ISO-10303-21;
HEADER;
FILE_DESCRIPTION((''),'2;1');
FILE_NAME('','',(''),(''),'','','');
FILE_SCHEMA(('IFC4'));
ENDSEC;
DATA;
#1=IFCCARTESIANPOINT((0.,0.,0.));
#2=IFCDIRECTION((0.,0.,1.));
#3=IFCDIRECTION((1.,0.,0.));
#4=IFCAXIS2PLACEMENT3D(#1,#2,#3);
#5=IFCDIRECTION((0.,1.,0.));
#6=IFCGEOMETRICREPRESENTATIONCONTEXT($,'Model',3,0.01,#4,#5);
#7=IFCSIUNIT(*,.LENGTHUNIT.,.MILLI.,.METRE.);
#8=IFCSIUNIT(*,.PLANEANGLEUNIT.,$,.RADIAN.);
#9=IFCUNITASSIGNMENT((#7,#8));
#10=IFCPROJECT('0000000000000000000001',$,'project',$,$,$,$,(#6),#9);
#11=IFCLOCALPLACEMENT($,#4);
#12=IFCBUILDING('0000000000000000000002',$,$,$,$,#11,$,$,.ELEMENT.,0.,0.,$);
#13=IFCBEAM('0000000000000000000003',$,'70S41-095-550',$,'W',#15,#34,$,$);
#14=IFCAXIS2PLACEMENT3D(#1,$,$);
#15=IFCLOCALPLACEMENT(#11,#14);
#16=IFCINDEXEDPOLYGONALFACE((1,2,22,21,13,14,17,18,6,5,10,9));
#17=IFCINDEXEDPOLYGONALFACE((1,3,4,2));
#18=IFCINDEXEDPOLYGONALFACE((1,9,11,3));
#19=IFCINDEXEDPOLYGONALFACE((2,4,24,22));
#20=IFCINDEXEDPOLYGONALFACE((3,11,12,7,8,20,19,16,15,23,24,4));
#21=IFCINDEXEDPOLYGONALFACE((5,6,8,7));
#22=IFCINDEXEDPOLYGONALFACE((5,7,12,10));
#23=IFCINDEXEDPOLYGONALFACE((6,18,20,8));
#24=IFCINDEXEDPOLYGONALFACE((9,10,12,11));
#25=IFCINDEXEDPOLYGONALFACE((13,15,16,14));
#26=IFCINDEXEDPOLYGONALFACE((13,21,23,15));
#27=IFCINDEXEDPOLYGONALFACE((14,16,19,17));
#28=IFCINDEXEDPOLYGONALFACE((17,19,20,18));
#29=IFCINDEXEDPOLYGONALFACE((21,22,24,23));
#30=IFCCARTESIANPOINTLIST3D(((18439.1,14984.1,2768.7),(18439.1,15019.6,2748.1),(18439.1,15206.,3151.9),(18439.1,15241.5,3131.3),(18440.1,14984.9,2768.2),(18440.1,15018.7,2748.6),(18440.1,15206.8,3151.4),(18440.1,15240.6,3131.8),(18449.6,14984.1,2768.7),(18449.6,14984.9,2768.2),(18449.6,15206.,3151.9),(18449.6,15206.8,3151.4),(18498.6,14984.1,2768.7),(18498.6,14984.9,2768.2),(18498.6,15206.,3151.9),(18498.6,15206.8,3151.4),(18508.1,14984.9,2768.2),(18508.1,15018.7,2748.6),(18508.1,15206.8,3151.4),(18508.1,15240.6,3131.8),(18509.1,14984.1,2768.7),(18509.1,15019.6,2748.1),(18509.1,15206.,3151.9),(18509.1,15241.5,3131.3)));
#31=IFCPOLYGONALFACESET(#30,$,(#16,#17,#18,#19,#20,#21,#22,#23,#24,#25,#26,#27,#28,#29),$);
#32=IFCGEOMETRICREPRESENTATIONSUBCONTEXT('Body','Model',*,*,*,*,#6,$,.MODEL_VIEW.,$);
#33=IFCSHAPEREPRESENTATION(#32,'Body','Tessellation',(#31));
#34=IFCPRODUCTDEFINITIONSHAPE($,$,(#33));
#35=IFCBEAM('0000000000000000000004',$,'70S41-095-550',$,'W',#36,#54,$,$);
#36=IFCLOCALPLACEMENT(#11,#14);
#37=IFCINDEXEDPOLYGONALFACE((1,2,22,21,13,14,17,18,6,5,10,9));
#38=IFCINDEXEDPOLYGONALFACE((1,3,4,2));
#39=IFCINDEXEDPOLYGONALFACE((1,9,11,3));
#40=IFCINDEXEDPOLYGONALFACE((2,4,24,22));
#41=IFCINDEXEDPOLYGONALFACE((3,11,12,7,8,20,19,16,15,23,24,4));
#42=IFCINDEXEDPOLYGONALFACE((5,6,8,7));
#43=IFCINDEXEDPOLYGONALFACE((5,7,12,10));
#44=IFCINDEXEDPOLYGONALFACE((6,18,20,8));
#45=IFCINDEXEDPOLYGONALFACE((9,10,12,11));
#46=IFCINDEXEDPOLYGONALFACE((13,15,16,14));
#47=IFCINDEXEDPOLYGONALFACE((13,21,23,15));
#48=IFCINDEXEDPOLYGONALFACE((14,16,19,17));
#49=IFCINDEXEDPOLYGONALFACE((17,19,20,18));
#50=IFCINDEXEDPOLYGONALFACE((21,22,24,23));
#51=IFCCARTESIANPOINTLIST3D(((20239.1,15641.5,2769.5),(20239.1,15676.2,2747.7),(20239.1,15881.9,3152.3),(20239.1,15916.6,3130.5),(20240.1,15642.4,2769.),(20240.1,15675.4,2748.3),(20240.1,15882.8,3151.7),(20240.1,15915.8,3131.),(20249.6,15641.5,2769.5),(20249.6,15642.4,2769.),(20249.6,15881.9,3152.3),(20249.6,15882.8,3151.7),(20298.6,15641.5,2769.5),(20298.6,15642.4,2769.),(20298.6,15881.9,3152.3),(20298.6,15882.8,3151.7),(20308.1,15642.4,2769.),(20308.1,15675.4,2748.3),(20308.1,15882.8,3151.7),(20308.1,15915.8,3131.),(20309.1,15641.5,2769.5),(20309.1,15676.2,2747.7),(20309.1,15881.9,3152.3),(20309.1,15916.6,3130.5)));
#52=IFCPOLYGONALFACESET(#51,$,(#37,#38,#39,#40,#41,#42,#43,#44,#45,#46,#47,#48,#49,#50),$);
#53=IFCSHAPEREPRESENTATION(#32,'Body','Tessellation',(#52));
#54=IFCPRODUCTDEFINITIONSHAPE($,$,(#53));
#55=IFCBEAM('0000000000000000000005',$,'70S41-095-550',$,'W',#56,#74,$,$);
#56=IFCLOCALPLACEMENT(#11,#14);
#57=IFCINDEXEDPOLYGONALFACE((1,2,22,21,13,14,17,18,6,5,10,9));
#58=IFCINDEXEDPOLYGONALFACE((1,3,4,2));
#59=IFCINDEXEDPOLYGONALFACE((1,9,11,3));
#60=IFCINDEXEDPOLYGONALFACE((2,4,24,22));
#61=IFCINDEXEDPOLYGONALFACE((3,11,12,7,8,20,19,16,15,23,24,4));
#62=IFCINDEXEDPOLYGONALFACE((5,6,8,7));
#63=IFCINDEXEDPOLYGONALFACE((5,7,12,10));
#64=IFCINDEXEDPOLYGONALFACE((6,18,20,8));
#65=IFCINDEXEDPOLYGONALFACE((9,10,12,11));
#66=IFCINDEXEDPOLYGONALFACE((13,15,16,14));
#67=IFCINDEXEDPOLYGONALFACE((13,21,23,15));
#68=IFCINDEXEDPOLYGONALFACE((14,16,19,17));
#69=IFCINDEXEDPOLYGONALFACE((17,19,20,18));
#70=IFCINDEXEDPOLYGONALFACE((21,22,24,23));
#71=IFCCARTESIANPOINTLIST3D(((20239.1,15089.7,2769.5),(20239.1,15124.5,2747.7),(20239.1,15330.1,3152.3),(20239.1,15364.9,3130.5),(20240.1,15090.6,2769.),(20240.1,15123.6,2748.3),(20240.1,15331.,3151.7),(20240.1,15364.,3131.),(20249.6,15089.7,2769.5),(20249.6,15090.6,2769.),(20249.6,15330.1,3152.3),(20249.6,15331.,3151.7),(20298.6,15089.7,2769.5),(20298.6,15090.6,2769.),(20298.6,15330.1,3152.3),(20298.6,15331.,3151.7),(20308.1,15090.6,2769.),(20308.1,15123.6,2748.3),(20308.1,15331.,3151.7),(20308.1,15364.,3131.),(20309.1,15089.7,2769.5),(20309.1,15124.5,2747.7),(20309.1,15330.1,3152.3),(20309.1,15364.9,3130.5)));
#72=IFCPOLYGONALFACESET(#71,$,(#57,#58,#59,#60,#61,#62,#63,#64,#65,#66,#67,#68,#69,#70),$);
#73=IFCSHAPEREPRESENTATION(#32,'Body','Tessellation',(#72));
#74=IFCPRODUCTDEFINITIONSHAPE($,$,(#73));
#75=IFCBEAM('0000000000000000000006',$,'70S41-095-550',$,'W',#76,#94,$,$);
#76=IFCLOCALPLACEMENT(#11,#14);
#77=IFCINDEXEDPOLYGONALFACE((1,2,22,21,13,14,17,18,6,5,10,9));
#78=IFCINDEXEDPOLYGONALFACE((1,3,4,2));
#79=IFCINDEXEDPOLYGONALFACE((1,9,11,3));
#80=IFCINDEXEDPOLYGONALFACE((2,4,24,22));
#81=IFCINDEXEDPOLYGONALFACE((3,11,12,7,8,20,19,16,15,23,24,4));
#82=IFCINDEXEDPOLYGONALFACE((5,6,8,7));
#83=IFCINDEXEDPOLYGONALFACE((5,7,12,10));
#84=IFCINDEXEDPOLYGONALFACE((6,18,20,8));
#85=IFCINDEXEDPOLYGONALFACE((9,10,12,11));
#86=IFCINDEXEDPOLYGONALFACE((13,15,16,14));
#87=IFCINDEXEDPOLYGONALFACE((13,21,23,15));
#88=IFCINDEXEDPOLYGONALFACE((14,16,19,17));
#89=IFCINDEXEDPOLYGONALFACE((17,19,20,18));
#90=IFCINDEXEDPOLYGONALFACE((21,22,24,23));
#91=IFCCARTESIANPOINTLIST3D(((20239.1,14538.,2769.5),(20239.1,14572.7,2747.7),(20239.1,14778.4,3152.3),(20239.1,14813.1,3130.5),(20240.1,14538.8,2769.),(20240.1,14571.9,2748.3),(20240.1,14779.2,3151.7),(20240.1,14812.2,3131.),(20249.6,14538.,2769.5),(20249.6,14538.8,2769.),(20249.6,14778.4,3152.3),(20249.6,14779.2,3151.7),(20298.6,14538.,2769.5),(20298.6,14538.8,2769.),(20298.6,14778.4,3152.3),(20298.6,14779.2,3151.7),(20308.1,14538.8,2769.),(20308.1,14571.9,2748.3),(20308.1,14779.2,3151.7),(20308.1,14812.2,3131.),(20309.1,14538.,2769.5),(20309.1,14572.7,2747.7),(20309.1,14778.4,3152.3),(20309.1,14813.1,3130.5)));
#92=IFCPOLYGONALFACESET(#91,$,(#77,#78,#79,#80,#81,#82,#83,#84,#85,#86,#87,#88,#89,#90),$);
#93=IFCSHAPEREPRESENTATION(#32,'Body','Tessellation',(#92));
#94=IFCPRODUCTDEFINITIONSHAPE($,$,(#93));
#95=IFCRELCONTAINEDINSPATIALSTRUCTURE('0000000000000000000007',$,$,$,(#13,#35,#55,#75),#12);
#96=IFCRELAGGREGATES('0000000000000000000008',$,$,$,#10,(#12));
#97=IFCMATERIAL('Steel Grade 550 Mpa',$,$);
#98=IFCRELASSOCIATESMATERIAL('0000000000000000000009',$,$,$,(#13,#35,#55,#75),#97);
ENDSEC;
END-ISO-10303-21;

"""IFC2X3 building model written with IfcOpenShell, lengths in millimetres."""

from ifc_helpers import new_model, si_unit, direction, frame, origin, origin_with_axes, origin_2d_with_axis, place, context, subcontext, project, spatial, c_section, extrude, source, transform, mapped, material, element, save


model = new_model("IFC2X3")

# Units and contexts
model_context = context("Model", 3, precision=0.01, world=origin_with_axes(), true_north=direction((0.0, 1.0, 0.0)))
body_context = subcontext(model_context, "Body", "Model", "MODEL_VIEW")
ifc_project = project(units=[si_unit("LENGTHUNIT", "METRE", prefix="MILLI"), si_unit("PLANEANGLEUNIT", "RADIAN")], contexts=[model_context])

# Building
building_placement = place(None, origin_with_axes())
building = spatial("IfcBuilding", under=ifc_project, at=building_placement, CompositionType="ELEMENT", ElevationOfRefHeight=0.0, ElevationOfTerrain=0.0)

# Shared definitions
ifc_material = material(Name="Steel Grade 550 Mpa")

# Beams
shared_shape_1 = source(origin(), body_context, "Body", "SweptSolid", [
    extrude(c_section(Depth=70.0, Width=41.0, WallThickness=1.0, Girth=10.5, at=origin_2d_with_axis()), origin_with_axes(), (0.0, 0.0, 1.0), 442.8),
])
beam_1_placement = place(None, frame((18474.1, 15001.8, 2758.4), z_axis=(0.0, 0.501095, 0.865392), x_axis=(0.0, -0.865392, 0.501095)))
element("IfcBeam", 1, at=beam_1_placement, inside=building, material=ifc_material, Name="70S41-095-550", ObjectType="W", context=body_context, shape_type="MappedRepresentation", body=[
    mapped(shared_shape_1, transform((0.0, 0.0, 0.0), scale=1.0)),
])
shared_shape_2 = source(origin(), body_context, "Body", "SweptSolid", [
    extrude(c_section(Depth=70.0, Width=41.0, WallThickness=1.0, Girth=10.5, at=origin_2d_with_axis()), origin_with_axes(), (0.0, 0.0, 1.0), 451.9),
])
beam_2_placement = place(None, frame((20274.1, 15658.9, 2758.6), z_axis=(0.0, 0.531898, 0.846809), x_axis=(0.0, -0.846809, 0.531898)))
element("IfcBeam", 2, at=beam_2_placement, inside=building, material=ifc_material, Name="70S41-095-550", ObjectType="W", context=body_context, shape_type="MappedRepresentation", body=[
    mapped(shared_shape_2, transform((0.0, 0.0, 0.0), scale=1.0)),
])
shared_shape_3 = source(origin(), body_context, "Body", "SweptSolid", [
    extrude(c_section(Depth=70.0, Width=41.0, WallThickness=1.0, Girth=10.5, at=origin_2d_with_axis()), origin_with_axes(), (0.0, 0.0, 1.0), 451.9),
])
beam_3_placement = place(None, frame((20274.1, 15107.1, 2758.6), z_axis=(0.0, 0.531898, 0.846809), x_axis=(0.0, -0.846809, 0.531898)))
element("IfcBeam", 3, at=beam_3_placement, inside=building, material=ifc_material, Name="70S41-095-550", ObjectType="W", context=body_context, shape_type="MappedRepresentation", body=[
    mapped(shared_shape_3, transform((0.0, 0.0, 0.0), scale=1.0)),
])
shared_shape_4 = source(origin(), body_context, "Body", "SweptSolid", [
    extrude(c_section(Depth=70.0, Width=41.0, WallThickness=1.0, Girth=10.5, at=origin_2d_with_axis()), origin_with_axes(), (0.0, 0.0, 1.0), 451.9),
])
beam_4_placement = place(None, frame((20274.1, 14555.3, 2758.6), z_axis=(0.0, 0.531898, 0.846809), x_axis=(0.0, -0.846809, 0.531898)))
element("IfcBeam", 4, at=beam_4_placement, inside=building, material=ifc_material, Name="70S41-095-550", ObjectType="W", context=body_context, shape_type="MappedRepresentation", body=[
    mapped(shared_shape_4, transform((0.0, 0.0, 0.0), scale=1.0)),
])

save(model, "model.ifc")
